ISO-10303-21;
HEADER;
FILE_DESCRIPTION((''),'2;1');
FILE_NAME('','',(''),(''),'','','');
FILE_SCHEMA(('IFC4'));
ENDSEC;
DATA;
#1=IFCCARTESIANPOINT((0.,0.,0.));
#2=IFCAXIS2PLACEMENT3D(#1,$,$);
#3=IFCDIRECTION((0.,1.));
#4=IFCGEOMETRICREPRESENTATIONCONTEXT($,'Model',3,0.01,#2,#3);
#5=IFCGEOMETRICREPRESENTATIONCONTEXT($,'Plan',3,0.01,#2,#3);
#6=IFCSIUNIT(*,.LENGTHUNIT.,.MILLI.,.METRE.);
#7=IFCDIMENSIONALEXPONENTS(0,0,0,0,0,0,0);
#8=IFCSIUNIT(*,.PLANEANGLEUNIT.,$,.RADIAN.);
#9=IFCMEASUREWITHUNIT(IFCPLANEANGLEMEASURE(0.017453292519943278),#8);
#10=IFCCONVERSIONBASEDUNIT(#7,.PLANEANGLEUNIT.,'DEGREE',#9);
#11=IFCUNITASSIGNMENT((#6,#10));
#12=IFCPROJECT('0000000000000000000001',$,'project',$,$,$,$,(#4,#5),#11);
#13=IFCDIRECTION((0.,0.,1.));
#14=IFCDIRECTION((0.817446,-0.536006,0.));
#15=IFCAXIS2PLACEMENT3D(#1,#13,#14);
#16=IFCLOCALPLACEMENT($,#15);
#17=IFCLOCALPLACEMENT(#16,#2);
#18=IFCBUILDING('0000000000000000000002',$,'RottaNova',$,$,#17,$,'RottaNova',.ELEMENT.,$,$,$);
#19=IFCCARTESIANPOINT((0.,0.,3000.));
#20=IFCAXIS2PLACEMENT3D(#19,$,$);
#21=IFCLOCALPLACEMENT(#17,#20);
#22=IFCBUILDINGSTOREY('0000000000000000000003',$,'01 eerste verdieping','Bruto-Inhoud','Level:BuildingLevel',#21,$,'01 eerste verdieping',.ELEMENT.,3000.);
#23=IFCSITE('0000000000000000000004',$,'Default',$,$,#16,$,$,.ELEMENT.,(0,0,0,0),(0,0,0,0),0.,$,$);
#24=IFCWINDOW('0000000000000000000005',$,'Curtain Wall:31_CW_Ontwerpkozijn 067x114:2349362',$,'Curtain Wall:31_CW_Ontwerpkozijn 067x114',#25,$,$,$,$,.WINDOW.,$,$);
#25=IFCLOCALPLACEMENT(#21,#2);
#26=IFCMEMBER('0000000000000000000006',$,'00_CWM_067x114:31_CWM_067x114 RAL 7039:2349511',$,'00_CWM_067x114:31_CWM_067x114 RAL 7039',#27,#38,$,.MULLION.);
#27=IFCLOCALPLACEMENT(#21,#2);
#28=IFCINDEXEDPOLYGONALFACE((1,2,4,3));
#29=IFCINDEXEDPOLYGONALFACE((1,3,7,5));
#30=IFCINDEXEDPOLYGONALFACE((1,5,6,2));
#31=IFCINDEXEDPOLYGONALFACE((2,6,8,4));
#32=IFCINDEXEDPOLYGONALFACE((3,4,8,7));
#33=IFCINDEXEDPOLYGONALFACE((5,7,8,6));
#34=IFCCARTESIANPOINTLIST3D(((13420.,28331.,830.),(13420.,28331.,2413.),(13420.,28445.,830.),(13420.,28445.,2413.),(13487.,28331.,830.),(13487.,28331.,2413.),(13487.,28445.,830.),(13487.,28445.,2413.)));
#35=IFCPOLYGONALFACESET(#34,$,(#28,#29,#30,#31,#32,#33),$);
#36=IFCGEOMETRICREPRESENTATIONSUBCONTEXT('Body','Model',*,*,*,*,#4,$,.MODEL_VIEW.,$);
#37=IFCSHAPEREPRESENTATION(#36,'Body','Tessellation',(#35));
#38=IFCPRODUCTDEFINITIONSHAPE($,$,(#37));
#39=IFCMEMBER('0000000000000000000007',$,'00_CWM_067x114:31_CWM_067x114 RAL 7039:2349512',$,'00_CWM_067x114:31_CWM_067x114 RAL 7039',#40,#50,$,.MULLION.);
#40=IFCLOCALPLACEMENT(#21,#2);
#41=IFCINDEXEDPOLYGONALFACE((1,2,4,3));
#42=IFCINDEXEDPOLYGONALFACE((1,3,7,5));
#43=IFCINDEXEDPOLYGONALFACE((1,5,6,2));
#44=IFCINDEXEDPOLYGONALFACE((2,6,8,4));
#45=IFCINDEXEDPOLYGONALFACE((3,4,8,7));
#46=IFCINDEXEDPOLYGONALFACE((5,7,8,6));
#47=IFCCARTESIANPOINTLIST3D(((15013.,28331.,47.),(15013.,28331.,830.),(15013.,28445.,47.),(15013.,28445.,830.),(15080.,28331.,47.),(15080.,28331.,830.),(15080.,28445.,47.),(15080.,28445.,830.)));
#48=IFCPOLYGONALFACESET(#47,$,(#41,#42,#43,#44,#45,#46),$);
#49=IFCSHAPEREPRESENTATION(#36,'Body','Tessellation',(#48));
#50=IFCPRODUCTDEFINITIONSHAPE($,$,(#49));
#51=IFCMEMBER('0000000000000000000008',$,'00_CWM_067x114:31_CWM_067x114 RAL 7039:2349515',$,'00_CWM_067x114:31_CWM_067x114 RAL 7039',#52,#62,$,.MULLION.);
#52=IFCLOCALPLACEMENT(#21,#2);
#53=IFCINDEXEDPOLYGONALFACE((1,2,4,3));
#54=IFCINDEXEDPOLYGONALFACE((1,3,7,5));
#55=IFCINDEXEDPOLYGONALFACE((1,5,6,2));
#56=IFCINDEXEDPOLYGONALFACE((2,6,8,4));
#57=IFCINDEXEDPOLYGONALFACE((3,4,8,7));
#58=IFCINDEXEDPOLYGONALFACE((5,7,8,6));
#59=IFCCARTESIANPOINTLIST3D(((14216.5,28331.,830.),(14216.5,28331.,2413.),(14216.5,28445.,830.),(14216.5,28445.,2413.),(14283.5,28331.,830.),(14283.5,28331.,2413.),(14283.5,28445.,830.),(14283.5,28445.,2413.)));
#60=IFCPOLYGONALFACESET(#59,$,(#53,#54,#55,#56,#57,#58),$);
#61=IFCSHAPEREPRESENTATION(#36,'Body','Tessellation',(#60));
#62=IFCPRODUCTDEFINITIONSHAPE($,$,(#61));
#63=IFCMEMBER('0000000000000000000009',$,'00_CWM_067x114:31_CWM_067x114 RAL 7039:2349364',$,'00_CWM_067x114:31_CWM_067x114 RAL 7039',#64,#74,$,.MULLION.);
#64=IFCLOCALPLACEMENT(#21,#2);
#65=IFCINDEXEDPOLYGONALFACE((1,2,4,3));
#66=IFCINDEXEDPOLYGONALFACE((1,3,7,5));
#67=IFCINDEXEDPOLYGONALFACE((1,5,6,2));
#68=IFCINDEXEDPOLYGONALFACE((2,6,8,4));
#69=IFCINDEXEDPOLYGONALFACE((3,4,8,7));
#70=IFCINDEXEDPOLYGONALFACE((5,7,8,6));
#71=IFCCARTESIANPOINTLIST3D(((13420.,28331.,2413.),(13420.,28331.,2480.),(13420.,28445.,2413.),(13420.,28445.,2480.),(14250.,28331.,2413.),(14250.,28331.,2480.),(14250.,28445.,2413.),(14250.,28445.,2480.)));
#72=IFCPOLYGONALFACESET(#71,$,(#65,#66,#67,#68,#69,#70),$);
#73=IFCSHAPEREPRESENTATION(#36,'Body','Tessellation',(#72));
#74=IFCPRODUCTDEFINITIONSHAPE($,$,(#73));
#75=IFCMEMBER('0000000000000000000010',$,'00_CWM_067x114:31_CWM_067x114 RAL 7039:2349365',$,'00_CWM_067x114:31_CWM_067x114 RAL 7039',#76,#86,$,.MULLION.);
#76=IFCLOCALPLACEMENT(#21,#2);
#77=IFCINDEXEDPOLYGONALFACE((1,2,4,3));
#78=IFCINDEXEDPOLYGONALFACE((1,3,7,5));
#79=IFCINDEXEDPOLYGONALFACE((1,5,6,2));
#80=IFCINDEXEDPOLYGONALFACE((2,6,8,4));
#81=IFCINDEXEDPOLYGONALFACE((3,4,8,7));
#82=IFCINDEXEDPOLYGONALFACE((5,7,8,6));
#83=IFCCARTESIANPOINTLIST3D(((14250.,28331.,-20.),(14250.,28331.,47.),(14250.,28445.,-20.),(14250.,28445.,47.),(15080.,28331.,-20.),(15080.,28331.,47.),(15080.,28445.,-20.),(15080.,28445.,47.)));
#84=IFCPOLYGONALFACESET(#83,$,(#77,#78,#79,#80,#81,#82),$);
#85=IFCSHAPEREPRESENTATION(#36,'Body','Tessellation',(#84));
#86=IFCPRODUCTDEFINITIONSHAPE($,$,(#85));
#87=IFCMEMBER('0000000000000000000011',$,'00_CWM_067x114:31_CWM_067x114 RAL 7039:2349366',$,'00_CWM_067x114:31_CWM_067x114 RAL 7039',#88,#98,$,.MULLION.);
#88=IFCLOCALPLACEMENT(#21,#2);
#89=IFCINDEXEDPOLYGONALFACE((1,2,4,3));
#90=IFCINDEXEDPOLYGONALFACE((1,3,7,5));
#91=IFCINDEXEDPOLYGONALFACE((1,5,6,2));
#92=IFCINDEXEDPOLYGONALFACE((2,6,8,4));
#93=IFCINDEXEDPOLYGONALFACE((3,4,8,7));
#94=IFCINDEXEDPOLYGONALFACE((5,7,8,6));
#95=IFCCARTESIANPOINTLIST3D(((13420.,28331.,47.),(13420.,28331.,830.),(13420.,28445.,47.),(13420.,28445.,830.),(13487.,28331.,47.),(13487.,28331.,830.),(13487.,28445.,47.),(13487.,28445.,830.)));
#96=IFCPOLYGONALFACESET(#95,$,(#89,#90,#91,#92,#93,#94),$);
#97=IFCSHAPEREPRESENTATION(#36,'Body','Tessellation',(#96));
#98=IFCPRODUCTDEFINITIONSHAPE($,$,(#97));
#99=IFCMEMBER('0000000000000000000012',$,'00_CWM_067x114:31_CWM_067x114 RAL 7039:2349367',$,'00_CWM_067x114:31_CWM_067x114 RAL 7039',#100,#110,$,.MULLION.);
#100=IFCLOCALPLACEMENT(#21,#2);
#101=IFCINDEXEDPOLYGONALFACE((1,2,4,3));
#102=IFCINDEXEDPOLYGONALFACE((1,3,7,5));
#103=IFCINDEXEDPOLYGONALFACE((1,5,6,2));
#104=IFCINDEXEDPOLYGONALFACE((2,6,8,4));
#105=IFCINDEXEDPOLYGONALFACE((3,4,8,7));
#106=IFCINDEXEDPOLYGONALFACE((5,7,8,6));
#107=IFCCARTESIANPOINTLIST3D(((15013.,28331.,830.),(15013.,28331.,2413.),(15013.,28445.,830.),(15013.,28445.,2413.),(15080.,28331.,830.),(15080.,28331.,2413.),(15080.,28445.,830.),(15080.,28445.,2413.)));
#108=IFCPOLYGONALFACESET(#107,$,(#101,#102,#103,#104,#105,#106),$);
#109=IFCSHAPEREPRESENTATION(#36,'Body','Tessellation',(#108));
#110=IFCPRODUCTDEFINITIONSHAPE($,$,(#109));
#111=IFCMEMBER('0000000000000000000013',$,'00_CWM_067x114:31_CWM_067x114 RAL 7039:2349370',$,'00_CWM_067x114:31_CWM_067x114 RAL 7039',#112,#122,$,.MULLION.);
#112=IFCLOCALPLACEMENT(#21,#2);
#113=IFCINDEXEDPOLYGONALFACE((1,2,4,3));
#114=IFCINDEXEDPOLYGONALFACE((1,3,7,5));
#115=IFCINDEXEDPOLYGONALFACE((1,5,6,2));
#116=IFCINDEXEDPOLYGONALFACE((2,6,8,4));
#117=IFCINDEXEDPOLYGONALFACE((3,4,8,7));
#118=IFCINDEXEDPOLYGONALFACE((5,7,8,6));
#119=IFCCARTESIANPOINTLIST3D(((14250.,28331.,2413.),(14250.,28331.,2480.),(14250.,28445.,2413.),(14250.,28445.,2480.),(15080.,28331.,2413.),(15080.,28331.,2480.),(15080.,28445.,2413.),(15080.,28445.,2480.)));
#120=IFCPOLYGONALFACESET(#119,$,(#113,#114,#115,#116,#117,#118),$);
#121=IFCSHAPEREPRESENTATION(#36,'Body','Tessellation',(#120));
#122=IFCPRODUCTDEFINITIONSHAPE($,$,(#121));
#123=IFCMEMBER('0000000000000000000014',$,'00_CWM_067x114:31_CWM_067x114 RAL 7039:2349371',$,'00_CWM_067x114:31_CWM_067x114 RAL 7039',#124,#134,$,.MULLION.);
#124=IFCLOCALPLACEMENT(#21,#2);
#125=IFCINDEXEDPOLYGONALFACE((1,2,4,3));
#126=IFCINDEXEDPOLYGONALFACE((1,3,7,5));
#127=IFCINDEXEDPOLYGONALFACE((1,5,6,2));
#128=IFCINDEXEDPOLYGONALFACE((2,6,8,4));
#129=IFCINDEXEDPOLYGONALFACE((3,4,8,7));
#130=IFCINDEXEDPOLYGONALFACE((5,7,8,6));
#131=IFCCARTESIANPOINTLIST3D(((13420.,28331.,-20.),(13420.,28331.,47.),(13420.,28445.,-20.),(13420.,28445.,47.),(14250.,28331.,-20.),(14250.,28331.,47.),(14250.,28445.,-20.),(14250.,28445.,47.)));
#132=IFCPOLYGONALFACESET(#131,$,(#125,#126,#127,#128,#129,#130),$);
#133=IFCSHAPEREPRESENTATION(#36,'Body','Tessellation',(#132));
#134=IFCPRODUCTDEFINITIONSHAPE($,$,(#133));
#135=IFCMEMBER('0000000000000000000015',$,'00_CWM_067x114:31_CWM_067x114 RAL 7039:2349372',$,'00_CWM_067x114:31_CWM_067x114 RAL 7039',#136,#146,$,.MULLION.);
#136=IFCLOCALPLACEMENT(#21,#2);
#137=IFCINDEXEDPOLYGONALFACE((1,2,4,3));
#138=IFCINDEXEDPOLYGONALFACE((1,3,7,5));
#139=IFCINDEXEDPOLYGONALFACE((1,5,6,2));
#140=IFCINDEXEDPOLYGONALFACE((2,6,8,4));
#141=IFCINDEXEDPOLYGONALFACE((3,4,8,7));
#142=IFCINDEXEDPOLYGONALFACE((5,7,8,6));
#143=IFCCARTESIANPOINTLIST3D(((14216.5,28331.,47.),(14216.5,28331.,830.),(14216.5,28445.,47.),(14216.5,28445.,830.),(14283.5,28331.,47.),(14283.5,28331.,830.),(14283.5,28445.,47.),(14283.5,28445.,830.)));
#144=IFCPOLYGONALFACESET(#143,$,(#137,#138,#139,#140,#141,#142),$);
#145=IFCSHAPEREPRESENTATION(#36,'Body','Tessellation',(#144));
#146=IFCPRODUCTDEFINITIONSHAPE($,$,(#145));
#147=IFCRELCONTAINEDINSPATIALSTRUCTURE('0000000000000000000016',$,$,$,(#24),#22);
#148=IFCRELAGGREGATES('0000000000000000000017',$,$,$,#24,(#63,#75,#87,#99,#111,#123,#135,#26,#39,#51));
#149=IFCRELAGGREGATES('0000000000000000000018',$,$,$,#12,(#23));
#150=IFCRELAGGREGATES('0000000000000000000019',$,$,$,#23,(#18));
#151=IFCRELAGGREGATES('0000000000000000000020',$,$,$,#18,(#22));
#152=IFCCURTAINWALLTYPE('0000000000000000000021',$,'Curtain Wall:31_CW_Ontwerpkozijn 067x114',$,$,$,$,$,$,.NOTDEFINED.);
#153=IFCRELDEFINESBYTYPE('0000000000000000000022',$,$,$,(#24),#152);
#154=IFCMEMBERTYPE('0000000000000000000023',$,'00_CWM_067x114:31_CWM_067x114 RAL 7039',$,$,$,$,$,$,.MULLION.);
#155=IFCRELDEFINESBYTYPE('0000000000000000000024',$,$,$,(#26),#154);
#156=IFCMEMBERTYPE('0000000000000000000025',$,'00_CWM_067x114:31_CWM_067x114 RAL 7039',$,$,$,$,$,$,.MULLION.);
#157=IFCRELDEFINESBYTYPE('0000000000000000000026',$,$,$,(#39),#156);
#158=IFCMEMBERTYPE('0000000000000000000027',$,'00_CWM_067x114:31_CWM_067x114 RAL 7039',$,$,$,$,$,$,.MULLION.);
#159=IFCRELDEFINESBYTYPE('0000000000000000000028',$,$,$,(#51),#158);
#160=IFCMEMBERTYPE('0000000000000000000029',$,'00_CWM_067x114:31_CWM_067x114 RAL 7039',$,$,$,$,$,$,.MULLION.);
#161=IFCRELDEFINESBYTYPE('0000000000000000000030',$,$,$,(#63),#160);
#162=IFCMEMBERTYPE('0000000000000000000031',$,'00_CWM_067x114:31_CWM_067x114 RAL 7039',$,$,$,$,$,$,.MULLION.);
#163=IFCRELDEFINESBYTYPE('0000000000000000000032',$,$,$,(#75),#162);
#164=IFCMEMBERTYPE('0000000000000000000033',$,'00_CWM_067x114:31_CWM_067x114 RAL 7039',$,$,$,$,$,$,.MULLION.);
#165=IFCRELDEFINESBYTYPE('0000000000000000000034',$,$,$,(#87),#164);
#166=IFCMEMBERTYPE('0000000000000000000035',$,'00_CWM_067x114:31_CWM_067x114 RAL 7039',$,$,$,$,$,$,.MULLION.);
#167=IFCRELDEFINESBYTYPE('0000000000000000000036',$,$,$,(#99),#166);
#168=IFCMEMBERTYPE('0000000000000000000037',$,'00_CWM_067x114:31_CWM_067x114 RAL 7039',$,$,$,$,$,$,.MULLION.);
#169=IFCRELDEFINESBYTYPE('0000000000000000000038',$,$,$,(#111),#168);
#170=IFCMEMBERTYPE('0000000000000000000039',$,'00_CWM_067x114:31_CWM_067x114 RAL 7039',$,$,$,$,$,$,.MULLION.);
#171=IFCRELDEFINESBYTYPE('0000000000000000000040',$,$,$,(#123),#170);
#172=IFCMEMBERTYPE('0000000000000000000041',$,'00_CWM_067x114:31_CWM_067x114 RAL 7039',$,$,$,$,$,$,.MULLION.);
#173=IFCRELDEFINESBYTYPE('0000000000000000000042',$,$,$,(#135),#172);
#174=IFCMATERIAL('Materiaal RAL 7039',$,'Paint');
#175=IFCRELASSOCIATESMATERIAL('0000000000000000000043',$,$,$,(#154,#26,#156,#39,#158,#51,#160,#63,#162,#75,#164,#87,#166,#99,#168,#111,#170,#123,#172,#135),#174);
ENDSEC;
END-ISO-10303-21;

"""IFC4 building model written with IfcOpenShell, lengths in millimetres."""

from ifc_helpers import new_model, entity, si_unit, converted_unit, direction, frame, origin, place, context, subcontext, project, spatial, indexed_curve, outline, extrude, source, transform, mapped, material, type_object, type_shapes, element, aggregate, save


model = new_model("IFC4")

# Units and contexts
model_context = context("Model", 3, precision=0.01, world=origin(), true_north=direction((0.0, 1.0)))
plan_context = context("Plan", 3, precision=0.01, world=origin(), true_north=direction((0.0, 1.0)))
body_context = subcontext(model_context, "Body", "Model", "MODEL_VIEW")
ifc_project = project(units=[si_unit("LENGTHUNIT", "METRE", prefix="MILLI"), converted_unit("PLANEANGLEUNIT", "DEGREE", entity("IfcPlaneAngleMeasure", 0.017453292519943278), si_unit("PLANEANGLEUNIT", "RADIAN"), dimensions=[0, 0, 0, 0, 0, 0, 0])], contexts=[model_context, plan_context])

# Site, building, storey
site_placement = place(None, frame((0.0, 0.0, 0.0), z_axis=(0.0, 0.0, 1.0), x_axis=(0.817446, -0.536006, 0.0)))
site = spatial("IfcSite", under=ifc_project, at=site_placement, Name="Default", CompositionType="ELEMENT", RefLatitude=(0, 0, 0, 0), RefLongitude=(0, 0, 0, 0), RefElevation=0.0)
building_placement = place(site_placement, origin())
building = spatial("IfcBuilding", under=site, at=building_placement, Name="RottaNova", LongName="RottaNova", CompositionType="ELEMENT")
storey_placement = place(building_placement, frame((0.0, 0.0, 3000.0)))
storey = spatial("IfcBuildingStorey", under=building, at=storey_placement, Name="01 eerste verdieping", Description="Bruto-Inhoud", ObjectType="Level:BuildingLevel", LongName="01 eerste verdieping", CompositionType="ELEMENT", Elevation=3000.0)

# Window, members
curtain_wall_type = type_object("IfcCurtainWallType", Name="Curtain Wall:31_CW_Ontwerpkozijn 067x114", PredefinedType="NOTDEFINED")
window_placement = place(storey_placement, frame((0.0, 0.0, -3000.0)))
window = element("IfcWindow", 1, at=window_placement, inside=storey, type_object=curtain_wall_type, Name="Curtain Wall:31_CW_Ontwerpkozijn 067x114:2349362", ObjectType="Curtain Wall:31_CW_Ontwerpkozijn 067x114", PredefinedType="WINDOW")
ifc_material_1 = material(Name="Materiaal RAL 7039", Category="Paint")
member_type_1 = type_object("IfcMemberType", Name="00_CWM_067x114:31_CWM_067x114 RAL 7039", PredefinedType="MULLION", material=ifc_material_1)
shared_shape_1 = source(origin(), body_context, "Body", "SweptSolid", [
    extrude(outline(indexed_curve([(-33.5, -57.0), (33.5, -57.0), (33.5, 57.0), (-33.5, 57.0), (-33.5, -57.0)], self_intersect=False)), frame((-33.5, 57.0, -1583.0), z_axis=(0.0, 0.0, 1.0), x_axis=(-1.0, 0.0, 0.0)), (0.0, 0.0, 1.0), 1583.0),
])
type_shapes(member_type_1, [shared_shape_1])
member_1_placement = place(window_placement, frame((13420.0, 28331.0, 3830.0), z_axis=(0.0, 0.0, -1.0), x_axis=(-1.0, 0.0, 0.0)))
member_1 = element("IfcMember", 2, at=member_1_placement, type_object=member_type_1, material=ifc_material_1, Name="00_CWM_067x114:31_CWM_067x114 RAL 7039:2349511", ObjectType="00_CWM_067x114:31_CWM_067x114 RAL 7039", PredefinedType="MULLION", context=body_context, shape_type="MappedRepresentation", body=[
    mapped(shared_shape_1, transform((0.0, 0.0, 0.0), scale=1.0)),
])
member_type_2 = type_object("IfcMemberType", Name="00_CWM_067x114:31_CWM_067x114 RAL 7039", PredefinedType="MULLION", material=ifc_material_1)
shared_shape_2 = source(origin(), body_context, "Body", "SweptSolid", [
    extrude(outline(indexed_curve([(-33.5, -57.0), (33.5, -57.0), (33.5, 57.0), (-33.5, 57.0), (-33.5, -57.0)], self_intersect=False)), frame((-33.5, 57.0, -783.0), z_axis=(0.0, 0.0, 1.0), x_axis=(-1.0, 0.0, 0.0)), (0.0, 0.0, 1.0), 783.0),
])
type_shapes(member_type_2, [shared_shape_2])
member_2_placement = place(window_placement, frame((15080.0, 28331.0, 3830.0)))
member_2 = element("IfcMember", 3, at=member_2_placement, type_object=member_type_2, material=ifc_material_1, Name="00_CWM_067x114:31_CWM_067x114 RAL 7039:2349512", ObjectType="00_CWM_067x114:31_CWM_067x114 RAL 7039", PredefinedType="MULLION", context=body_context, shape_type="MappedRepresentation", body=[
    mapped(shared_shape_2, transform((0.0, 0.0, 0.0), scale=1.0)),
])
member_type_3 = type_object("IfcMemberType", Name="00_CWM_067x114:31_CWM_067x114 RAL 7039", PredefinedType="MULLION", material=ifc_material_1)
shared_shape_3 = source(origin(), body_context, "Body", "SweptSolid", [
    extrude(outline(indexed_curve([(-33.5, -57.0), (33.5, -57.0), (33.5, 57.0), (-33.5, 57.0), (-33.5, -57.0)], self_intersect=False)), frame((0.0, 57.0, -1583.0), z_axis=(0.0, 0.0, 1.0), x_axis=(-1.0, 0.0, 0.0)), (0.0, 0.0, 1.0), 1583.0),
])
type_shapes(member_type_3, [shared_shape_3])
member_3_placement = place(window_placement, frame((14250.0, 28331.0, 3830.0), z_axis=(0.0, 0.0, -1.0), x_axis=(-1.0, 0.0, 0.0)))
member_3 = element("IfcMember", 4, at=member_3_placement, type_object=member_type_3, material=ifc_material_1, Name="00_CWM_067x114:31_CWM_067x114 RAL 7039:2349515", ObjectType="00_CWM_067x114:31_CWM_067x114 RAL 7039", PredefinedType="MULLION", context=body_context, shape_type="MappedRepresentation", body=[
    mapped(shared_shape_3, transform((0.0, 0.0, 0.0), scale=1.0)),
])
member_type_4 = type_object("IfcMemberType", Name="00_CWM_067x114:31_CWM_067x114 RAL 7039", PredefinedType="MULLION", material=ifc_material_1)
shared_shape_4 = source(origin(), body_context, "Body", "SweptSolid", [
    extrude(outline(indexed_curve([(-33.5, -57.0), (33.5, -57.0), (33.5, 57.0), (-33.5, 57.0), (-33.5, -57.0)], self_intersect=False)), frame((-33.5, 57.0, -830.0), z_axis=(0.0, 0.0, 1.0), x_axis=(-1.0, 0.0, 0.0)), (0.0, 0.0, 1.0), 830.0),
])
type_shapes(member_type_4, [shared_shape_4])
member_4_placement = place(window_placement, frame((13420.0, 28331.0, 5480.0), z_axis=(-1.0, 0.0, 0.0), x_axis=(0.0, 0.0, 1.0)))
member_4 = element("IfcMember", 5, at=member_4_placement, type_object=member_type_4, material=ifc_material_1, Name="00_CWM_067x114:31_CWM_067x114 RAL 7039:2349364", ObjectType="00_CWM_067x114:31_CWM_067x114 RAL 7039", PredefinedType="MULLION", context=body_context, shape_type="MappedRepresentation", body=[
    mapped(shared_shape_4, transform((0.0, 0.0, 0.0), scale=1.0)),
])
member_type_5 = type_object("IfcMemberType", Name="00_CWM_067x114:31_CWM_067x114 RAL 7039", PredefinedType="MULLION", material=ifc_material_1)
shared_shape_5 = source(origin(), body_context, "Body", "SweptSolid", [
    extrude(outline(indexed_curve([(-33.5, -57.0), (33.5, -57.0), (33.5, 57.0), (-33.5, 57.0), (-33.5, -57.0)], self_intersect=False)), frame((-33.5, 57.0, -830.0), z_axis=(0.0, 0.0, 1.0), x_axis=(-1.0, 0.0, 0.0)), (0.0, 0.0, 1.0), 830.0),
])
type_shapes(member_type_5, [shared_shape_5])
member_5_placement = place(window_placement, frame((15080.0, 28331.0, 2980.0), z_axis=(1.0, 0.0, 0.0), x_axis=(0.0, 0.0, -1.0)))
member_5 = element("IfcMember", 6, at=member_5_placement, type_object=member_type_5, material=ifc_material_1, Name="00_CWM_067x114:31_CWM_067x114 RAL 7039:2349365", ObjectType="00_CWM_067x114:31_CWM_067x114 RAL 7039", PredefinedType="MULLION", context=body_context, shape_type="MappedRepresentation", body=[
    mapped(shared_shape_5, transform((0.0, 0.0, 0.0), scale=1.0)),
])
member_type_6 = type_object("IfcMemberType", Name="00_CWM_067x114:31_CWM_067x114 RAL 7039", PredefinedType="MULLION", material=ifc_material_1)
shared_shape_6 = source(origin(), body_context, "Body", "SweptSolid", [
    extrude(outline(indexed_curve([(-33.5, -57.0), (33.5, -57.0), (33.5, 57.0), (-33.5, 57.0), (-33.5, -57.0)], self_intersect=False)), frame((-33.5, 57.0, -783.0), z_axis=(0.0, 0.0, 1.0), x_axis=(-1.0, 0.0, 0.0)), (0.0, 0.0, 1.0), 783.0),
])
type_shapes(member_type_6, [shared_shape_6])
member_6_placement = place(window_placement, frame((13420.0, 28331.0, 3047.0), z_axis=(0.0, 0.0, -1.0), x_axis=(-1.0, 0.0, 0.0)))
member_6 = element("IfcMember", 7, at=member_6_placement, type_object=member_type_6, material=ifc_material_1, Name="00_CWM_067x114:31_CWM_067x114 RAL 7039:2349366", ObjectType="00_CWM_067x114:31_CWM_067x114 RAL 7039", PredefinedType="MULLION", context=body_context, shape_type="MappedRepresentation", body=[
    mapped(shared_shape_6, transform((0.0, 0.0, 0.0), scale=1.0)),
])
member_type_7 = type_object("IfcMemberType", Name="00_CWM_067x114:31_CWM_067x114 RAL 7039", PredefinedType="MULLION", material=ifc_material_1)
shared_shape_7 = source(origin(), body_context, "Body", "SweptSolid", [
    extrude(outline(indexed_curve([(-33.5, -57.0), (33.5, -57.0), (33.5, 57.0), (-33.5, 57.0), (-33.5, -57.0)], self_intersect=False)), frame((-33.5, 57.0, -1583.0), z_axis=(0.0, 0.0, 1.0), x_axis=(-1.0, 0.0, 0.0)), (0.0, 0.0, 1.0), 1583.0),
])
type_shapes(member_type_7, [shared_shape_7])
member_7_placement = place(window_placement, frame((15080.0, 28331.0, 5413.0)))
member_7 = element("IfcMember", 8, at=member_7_placement, type_object=member_type_7, material=ifc_material_1, Name="00_CWM_067x114:31_CWM_067x114 RAL 7039:2349367", ObjectType="00_CWM_067x114:31_CWM_067x114 RAL 7039", PredefinedType="MULLION", context=body_context, shape_type="MappedRepresentation", body=[
    mapped(shared_shape_7, transform((0.0, 0.0, 0.0), scale=1.0)),
])
member_type_8 = type_object("IfcMemberType", Name="00_CWM_067x114:31_CWM_067x114 RAL 7039", PredefinedType="MULLION", material=ifc_material_1)
shared_shape_8 = source(origin(), body_context, "Body", "SweptSolid", [
    extrude(outline(indexed_curve([(-33.5, -57.0), (33.5, -57.0), (33.5, 57.0), (-33.5, 57.0), (-33.5, -57.0)], self_intersect=False)), frame((-33.5, 57.0, -830.0), z_axis=(0.0, 0.0, 1.0), x_axis=(-1.0, 0.0, 0.0)), (0.0, 0.0, 1.0), 830.0),
])
type_shapes(member_type_8, [shared_shape_8])
member_8_placement = place(window_placement, frame((14250.0, 28331.0, 5480.0), z_axis=(-1.0, 0.0, 0.0), x_axis=(0.0, 0.0, 1.0)))
member_8 = element("IfcMember", 9, at=member_8_placement, type_object=member_type_8, material=ifc_material_1, Name="00_CWM_067x114:31_CWM_067x114 RAL 7039:2349370", ObjectType="00_CWM_067x114:31_CWM_067x114 RAL 7039", PredefinedType="MULLION", context=body_context, shape_type="MappedRepresentation", body=[
    mapped(shared_shape_8, transform((0.0, 0.0, 0.0), scale=1.0)),
])
member_type_9 = type_object("IfcMemberType", Name="00_CWM_067x114:31_CWM_067x114 RAL 7039", PredefinedType="MULLION", material=ifc_material_1)
shared_shape_9 = source(origin(), body_context, "Body", "SweptSolid", [
    extrude(outline(indexed_curve([(-33.5, -57.0), (33.5, -57.0), (33.5, 57.0), (-33.5, 57.0), (-33.5, -57.0)], self_intersect=False)), frame((-33.5, 57.0, -830.0), z_axis=(0.0, 0.0, 1.0), x_axis=(-1.0, 0.0, 0.0)), (0.0, 0.0, 1.0), 830.0),
])
type_shapes(member_type_9, [shared_shape_9])
member_9_placement = place(window_placement, frame((14250.0, 28331.0, 2980.0), z_axis=(1.0, 0.0, 0.0), x_axis=(0.0, 0.0, -1.0)))
member_9 = element("IfcMember", 10, at=member_9_placement, type_object=member_type_9, material=ifc_material_1, Name="00_CWM_067x114:31_CWM_067x114 RAL 7039:2349371", ObjectType="00_CWM_067x114:31_CWM_067x114 RAL 7039", PredefinedType="MULLION", context=body_context, shape_type="MappedRepresentation", body=[
    mapped(shared_shape_9, transform((0.0, 0.0, 0.0), scale=1.0)),
])
member_type_10 = type_object("IfcMemberType", Name="00_CWM_067x114:31_CWM_067x114 RAL 7039", PredefinedType="MULLION", material=ifc_material_1)
shared_shape_10 = source(origin(), body_context, "Body", "SweptSolid", [
    extrude(outline(indexed_curve([(-33.5, -57.0), (33.5, -57.0), (33.5, 57.0), (-33.5, 57.0), (-33.5, -57.0)], self_intersect=False)), frame((0.0, 57.0, -783.0), z_axis=(0.0, 0.0, 1.0), x_axis=(-1.0, 0.0, 0.0)), (0.0, 0.0, 1.0), 783.0),
])
type_shapes(member_type_10, [shared_shape_10])
member_10_placement = place(window_placement, frame((14250.0, 28331.0, 3047.0), z_axis=(0.0, 0.0, -1.0), x_axis=(-1.0, 0.0, 0.0)))
member_10 = element("IfcMember", 11, at=member_10_placement, type_object=member_type_10, material=ifc_material_1, Name="00_CWM_067x114:31_CWM_067x114 RAL 7039:2349372", ObjectType="00_CWM_067x114:31_CWM_067x114 RAL 7039", PredefinedType="MULLION", context=body_context, shape_type="MappedRepresentation", body=[
    mapped(shared_shape_10, transform((0.0, 0.0, 0.0), scale=1.0)),
])
aggregate(window, [member_4, member_5, member_6, member_7, member_8, member_9, member_10, member_1, member_2, member_3])

save(model, "model.ifc")
